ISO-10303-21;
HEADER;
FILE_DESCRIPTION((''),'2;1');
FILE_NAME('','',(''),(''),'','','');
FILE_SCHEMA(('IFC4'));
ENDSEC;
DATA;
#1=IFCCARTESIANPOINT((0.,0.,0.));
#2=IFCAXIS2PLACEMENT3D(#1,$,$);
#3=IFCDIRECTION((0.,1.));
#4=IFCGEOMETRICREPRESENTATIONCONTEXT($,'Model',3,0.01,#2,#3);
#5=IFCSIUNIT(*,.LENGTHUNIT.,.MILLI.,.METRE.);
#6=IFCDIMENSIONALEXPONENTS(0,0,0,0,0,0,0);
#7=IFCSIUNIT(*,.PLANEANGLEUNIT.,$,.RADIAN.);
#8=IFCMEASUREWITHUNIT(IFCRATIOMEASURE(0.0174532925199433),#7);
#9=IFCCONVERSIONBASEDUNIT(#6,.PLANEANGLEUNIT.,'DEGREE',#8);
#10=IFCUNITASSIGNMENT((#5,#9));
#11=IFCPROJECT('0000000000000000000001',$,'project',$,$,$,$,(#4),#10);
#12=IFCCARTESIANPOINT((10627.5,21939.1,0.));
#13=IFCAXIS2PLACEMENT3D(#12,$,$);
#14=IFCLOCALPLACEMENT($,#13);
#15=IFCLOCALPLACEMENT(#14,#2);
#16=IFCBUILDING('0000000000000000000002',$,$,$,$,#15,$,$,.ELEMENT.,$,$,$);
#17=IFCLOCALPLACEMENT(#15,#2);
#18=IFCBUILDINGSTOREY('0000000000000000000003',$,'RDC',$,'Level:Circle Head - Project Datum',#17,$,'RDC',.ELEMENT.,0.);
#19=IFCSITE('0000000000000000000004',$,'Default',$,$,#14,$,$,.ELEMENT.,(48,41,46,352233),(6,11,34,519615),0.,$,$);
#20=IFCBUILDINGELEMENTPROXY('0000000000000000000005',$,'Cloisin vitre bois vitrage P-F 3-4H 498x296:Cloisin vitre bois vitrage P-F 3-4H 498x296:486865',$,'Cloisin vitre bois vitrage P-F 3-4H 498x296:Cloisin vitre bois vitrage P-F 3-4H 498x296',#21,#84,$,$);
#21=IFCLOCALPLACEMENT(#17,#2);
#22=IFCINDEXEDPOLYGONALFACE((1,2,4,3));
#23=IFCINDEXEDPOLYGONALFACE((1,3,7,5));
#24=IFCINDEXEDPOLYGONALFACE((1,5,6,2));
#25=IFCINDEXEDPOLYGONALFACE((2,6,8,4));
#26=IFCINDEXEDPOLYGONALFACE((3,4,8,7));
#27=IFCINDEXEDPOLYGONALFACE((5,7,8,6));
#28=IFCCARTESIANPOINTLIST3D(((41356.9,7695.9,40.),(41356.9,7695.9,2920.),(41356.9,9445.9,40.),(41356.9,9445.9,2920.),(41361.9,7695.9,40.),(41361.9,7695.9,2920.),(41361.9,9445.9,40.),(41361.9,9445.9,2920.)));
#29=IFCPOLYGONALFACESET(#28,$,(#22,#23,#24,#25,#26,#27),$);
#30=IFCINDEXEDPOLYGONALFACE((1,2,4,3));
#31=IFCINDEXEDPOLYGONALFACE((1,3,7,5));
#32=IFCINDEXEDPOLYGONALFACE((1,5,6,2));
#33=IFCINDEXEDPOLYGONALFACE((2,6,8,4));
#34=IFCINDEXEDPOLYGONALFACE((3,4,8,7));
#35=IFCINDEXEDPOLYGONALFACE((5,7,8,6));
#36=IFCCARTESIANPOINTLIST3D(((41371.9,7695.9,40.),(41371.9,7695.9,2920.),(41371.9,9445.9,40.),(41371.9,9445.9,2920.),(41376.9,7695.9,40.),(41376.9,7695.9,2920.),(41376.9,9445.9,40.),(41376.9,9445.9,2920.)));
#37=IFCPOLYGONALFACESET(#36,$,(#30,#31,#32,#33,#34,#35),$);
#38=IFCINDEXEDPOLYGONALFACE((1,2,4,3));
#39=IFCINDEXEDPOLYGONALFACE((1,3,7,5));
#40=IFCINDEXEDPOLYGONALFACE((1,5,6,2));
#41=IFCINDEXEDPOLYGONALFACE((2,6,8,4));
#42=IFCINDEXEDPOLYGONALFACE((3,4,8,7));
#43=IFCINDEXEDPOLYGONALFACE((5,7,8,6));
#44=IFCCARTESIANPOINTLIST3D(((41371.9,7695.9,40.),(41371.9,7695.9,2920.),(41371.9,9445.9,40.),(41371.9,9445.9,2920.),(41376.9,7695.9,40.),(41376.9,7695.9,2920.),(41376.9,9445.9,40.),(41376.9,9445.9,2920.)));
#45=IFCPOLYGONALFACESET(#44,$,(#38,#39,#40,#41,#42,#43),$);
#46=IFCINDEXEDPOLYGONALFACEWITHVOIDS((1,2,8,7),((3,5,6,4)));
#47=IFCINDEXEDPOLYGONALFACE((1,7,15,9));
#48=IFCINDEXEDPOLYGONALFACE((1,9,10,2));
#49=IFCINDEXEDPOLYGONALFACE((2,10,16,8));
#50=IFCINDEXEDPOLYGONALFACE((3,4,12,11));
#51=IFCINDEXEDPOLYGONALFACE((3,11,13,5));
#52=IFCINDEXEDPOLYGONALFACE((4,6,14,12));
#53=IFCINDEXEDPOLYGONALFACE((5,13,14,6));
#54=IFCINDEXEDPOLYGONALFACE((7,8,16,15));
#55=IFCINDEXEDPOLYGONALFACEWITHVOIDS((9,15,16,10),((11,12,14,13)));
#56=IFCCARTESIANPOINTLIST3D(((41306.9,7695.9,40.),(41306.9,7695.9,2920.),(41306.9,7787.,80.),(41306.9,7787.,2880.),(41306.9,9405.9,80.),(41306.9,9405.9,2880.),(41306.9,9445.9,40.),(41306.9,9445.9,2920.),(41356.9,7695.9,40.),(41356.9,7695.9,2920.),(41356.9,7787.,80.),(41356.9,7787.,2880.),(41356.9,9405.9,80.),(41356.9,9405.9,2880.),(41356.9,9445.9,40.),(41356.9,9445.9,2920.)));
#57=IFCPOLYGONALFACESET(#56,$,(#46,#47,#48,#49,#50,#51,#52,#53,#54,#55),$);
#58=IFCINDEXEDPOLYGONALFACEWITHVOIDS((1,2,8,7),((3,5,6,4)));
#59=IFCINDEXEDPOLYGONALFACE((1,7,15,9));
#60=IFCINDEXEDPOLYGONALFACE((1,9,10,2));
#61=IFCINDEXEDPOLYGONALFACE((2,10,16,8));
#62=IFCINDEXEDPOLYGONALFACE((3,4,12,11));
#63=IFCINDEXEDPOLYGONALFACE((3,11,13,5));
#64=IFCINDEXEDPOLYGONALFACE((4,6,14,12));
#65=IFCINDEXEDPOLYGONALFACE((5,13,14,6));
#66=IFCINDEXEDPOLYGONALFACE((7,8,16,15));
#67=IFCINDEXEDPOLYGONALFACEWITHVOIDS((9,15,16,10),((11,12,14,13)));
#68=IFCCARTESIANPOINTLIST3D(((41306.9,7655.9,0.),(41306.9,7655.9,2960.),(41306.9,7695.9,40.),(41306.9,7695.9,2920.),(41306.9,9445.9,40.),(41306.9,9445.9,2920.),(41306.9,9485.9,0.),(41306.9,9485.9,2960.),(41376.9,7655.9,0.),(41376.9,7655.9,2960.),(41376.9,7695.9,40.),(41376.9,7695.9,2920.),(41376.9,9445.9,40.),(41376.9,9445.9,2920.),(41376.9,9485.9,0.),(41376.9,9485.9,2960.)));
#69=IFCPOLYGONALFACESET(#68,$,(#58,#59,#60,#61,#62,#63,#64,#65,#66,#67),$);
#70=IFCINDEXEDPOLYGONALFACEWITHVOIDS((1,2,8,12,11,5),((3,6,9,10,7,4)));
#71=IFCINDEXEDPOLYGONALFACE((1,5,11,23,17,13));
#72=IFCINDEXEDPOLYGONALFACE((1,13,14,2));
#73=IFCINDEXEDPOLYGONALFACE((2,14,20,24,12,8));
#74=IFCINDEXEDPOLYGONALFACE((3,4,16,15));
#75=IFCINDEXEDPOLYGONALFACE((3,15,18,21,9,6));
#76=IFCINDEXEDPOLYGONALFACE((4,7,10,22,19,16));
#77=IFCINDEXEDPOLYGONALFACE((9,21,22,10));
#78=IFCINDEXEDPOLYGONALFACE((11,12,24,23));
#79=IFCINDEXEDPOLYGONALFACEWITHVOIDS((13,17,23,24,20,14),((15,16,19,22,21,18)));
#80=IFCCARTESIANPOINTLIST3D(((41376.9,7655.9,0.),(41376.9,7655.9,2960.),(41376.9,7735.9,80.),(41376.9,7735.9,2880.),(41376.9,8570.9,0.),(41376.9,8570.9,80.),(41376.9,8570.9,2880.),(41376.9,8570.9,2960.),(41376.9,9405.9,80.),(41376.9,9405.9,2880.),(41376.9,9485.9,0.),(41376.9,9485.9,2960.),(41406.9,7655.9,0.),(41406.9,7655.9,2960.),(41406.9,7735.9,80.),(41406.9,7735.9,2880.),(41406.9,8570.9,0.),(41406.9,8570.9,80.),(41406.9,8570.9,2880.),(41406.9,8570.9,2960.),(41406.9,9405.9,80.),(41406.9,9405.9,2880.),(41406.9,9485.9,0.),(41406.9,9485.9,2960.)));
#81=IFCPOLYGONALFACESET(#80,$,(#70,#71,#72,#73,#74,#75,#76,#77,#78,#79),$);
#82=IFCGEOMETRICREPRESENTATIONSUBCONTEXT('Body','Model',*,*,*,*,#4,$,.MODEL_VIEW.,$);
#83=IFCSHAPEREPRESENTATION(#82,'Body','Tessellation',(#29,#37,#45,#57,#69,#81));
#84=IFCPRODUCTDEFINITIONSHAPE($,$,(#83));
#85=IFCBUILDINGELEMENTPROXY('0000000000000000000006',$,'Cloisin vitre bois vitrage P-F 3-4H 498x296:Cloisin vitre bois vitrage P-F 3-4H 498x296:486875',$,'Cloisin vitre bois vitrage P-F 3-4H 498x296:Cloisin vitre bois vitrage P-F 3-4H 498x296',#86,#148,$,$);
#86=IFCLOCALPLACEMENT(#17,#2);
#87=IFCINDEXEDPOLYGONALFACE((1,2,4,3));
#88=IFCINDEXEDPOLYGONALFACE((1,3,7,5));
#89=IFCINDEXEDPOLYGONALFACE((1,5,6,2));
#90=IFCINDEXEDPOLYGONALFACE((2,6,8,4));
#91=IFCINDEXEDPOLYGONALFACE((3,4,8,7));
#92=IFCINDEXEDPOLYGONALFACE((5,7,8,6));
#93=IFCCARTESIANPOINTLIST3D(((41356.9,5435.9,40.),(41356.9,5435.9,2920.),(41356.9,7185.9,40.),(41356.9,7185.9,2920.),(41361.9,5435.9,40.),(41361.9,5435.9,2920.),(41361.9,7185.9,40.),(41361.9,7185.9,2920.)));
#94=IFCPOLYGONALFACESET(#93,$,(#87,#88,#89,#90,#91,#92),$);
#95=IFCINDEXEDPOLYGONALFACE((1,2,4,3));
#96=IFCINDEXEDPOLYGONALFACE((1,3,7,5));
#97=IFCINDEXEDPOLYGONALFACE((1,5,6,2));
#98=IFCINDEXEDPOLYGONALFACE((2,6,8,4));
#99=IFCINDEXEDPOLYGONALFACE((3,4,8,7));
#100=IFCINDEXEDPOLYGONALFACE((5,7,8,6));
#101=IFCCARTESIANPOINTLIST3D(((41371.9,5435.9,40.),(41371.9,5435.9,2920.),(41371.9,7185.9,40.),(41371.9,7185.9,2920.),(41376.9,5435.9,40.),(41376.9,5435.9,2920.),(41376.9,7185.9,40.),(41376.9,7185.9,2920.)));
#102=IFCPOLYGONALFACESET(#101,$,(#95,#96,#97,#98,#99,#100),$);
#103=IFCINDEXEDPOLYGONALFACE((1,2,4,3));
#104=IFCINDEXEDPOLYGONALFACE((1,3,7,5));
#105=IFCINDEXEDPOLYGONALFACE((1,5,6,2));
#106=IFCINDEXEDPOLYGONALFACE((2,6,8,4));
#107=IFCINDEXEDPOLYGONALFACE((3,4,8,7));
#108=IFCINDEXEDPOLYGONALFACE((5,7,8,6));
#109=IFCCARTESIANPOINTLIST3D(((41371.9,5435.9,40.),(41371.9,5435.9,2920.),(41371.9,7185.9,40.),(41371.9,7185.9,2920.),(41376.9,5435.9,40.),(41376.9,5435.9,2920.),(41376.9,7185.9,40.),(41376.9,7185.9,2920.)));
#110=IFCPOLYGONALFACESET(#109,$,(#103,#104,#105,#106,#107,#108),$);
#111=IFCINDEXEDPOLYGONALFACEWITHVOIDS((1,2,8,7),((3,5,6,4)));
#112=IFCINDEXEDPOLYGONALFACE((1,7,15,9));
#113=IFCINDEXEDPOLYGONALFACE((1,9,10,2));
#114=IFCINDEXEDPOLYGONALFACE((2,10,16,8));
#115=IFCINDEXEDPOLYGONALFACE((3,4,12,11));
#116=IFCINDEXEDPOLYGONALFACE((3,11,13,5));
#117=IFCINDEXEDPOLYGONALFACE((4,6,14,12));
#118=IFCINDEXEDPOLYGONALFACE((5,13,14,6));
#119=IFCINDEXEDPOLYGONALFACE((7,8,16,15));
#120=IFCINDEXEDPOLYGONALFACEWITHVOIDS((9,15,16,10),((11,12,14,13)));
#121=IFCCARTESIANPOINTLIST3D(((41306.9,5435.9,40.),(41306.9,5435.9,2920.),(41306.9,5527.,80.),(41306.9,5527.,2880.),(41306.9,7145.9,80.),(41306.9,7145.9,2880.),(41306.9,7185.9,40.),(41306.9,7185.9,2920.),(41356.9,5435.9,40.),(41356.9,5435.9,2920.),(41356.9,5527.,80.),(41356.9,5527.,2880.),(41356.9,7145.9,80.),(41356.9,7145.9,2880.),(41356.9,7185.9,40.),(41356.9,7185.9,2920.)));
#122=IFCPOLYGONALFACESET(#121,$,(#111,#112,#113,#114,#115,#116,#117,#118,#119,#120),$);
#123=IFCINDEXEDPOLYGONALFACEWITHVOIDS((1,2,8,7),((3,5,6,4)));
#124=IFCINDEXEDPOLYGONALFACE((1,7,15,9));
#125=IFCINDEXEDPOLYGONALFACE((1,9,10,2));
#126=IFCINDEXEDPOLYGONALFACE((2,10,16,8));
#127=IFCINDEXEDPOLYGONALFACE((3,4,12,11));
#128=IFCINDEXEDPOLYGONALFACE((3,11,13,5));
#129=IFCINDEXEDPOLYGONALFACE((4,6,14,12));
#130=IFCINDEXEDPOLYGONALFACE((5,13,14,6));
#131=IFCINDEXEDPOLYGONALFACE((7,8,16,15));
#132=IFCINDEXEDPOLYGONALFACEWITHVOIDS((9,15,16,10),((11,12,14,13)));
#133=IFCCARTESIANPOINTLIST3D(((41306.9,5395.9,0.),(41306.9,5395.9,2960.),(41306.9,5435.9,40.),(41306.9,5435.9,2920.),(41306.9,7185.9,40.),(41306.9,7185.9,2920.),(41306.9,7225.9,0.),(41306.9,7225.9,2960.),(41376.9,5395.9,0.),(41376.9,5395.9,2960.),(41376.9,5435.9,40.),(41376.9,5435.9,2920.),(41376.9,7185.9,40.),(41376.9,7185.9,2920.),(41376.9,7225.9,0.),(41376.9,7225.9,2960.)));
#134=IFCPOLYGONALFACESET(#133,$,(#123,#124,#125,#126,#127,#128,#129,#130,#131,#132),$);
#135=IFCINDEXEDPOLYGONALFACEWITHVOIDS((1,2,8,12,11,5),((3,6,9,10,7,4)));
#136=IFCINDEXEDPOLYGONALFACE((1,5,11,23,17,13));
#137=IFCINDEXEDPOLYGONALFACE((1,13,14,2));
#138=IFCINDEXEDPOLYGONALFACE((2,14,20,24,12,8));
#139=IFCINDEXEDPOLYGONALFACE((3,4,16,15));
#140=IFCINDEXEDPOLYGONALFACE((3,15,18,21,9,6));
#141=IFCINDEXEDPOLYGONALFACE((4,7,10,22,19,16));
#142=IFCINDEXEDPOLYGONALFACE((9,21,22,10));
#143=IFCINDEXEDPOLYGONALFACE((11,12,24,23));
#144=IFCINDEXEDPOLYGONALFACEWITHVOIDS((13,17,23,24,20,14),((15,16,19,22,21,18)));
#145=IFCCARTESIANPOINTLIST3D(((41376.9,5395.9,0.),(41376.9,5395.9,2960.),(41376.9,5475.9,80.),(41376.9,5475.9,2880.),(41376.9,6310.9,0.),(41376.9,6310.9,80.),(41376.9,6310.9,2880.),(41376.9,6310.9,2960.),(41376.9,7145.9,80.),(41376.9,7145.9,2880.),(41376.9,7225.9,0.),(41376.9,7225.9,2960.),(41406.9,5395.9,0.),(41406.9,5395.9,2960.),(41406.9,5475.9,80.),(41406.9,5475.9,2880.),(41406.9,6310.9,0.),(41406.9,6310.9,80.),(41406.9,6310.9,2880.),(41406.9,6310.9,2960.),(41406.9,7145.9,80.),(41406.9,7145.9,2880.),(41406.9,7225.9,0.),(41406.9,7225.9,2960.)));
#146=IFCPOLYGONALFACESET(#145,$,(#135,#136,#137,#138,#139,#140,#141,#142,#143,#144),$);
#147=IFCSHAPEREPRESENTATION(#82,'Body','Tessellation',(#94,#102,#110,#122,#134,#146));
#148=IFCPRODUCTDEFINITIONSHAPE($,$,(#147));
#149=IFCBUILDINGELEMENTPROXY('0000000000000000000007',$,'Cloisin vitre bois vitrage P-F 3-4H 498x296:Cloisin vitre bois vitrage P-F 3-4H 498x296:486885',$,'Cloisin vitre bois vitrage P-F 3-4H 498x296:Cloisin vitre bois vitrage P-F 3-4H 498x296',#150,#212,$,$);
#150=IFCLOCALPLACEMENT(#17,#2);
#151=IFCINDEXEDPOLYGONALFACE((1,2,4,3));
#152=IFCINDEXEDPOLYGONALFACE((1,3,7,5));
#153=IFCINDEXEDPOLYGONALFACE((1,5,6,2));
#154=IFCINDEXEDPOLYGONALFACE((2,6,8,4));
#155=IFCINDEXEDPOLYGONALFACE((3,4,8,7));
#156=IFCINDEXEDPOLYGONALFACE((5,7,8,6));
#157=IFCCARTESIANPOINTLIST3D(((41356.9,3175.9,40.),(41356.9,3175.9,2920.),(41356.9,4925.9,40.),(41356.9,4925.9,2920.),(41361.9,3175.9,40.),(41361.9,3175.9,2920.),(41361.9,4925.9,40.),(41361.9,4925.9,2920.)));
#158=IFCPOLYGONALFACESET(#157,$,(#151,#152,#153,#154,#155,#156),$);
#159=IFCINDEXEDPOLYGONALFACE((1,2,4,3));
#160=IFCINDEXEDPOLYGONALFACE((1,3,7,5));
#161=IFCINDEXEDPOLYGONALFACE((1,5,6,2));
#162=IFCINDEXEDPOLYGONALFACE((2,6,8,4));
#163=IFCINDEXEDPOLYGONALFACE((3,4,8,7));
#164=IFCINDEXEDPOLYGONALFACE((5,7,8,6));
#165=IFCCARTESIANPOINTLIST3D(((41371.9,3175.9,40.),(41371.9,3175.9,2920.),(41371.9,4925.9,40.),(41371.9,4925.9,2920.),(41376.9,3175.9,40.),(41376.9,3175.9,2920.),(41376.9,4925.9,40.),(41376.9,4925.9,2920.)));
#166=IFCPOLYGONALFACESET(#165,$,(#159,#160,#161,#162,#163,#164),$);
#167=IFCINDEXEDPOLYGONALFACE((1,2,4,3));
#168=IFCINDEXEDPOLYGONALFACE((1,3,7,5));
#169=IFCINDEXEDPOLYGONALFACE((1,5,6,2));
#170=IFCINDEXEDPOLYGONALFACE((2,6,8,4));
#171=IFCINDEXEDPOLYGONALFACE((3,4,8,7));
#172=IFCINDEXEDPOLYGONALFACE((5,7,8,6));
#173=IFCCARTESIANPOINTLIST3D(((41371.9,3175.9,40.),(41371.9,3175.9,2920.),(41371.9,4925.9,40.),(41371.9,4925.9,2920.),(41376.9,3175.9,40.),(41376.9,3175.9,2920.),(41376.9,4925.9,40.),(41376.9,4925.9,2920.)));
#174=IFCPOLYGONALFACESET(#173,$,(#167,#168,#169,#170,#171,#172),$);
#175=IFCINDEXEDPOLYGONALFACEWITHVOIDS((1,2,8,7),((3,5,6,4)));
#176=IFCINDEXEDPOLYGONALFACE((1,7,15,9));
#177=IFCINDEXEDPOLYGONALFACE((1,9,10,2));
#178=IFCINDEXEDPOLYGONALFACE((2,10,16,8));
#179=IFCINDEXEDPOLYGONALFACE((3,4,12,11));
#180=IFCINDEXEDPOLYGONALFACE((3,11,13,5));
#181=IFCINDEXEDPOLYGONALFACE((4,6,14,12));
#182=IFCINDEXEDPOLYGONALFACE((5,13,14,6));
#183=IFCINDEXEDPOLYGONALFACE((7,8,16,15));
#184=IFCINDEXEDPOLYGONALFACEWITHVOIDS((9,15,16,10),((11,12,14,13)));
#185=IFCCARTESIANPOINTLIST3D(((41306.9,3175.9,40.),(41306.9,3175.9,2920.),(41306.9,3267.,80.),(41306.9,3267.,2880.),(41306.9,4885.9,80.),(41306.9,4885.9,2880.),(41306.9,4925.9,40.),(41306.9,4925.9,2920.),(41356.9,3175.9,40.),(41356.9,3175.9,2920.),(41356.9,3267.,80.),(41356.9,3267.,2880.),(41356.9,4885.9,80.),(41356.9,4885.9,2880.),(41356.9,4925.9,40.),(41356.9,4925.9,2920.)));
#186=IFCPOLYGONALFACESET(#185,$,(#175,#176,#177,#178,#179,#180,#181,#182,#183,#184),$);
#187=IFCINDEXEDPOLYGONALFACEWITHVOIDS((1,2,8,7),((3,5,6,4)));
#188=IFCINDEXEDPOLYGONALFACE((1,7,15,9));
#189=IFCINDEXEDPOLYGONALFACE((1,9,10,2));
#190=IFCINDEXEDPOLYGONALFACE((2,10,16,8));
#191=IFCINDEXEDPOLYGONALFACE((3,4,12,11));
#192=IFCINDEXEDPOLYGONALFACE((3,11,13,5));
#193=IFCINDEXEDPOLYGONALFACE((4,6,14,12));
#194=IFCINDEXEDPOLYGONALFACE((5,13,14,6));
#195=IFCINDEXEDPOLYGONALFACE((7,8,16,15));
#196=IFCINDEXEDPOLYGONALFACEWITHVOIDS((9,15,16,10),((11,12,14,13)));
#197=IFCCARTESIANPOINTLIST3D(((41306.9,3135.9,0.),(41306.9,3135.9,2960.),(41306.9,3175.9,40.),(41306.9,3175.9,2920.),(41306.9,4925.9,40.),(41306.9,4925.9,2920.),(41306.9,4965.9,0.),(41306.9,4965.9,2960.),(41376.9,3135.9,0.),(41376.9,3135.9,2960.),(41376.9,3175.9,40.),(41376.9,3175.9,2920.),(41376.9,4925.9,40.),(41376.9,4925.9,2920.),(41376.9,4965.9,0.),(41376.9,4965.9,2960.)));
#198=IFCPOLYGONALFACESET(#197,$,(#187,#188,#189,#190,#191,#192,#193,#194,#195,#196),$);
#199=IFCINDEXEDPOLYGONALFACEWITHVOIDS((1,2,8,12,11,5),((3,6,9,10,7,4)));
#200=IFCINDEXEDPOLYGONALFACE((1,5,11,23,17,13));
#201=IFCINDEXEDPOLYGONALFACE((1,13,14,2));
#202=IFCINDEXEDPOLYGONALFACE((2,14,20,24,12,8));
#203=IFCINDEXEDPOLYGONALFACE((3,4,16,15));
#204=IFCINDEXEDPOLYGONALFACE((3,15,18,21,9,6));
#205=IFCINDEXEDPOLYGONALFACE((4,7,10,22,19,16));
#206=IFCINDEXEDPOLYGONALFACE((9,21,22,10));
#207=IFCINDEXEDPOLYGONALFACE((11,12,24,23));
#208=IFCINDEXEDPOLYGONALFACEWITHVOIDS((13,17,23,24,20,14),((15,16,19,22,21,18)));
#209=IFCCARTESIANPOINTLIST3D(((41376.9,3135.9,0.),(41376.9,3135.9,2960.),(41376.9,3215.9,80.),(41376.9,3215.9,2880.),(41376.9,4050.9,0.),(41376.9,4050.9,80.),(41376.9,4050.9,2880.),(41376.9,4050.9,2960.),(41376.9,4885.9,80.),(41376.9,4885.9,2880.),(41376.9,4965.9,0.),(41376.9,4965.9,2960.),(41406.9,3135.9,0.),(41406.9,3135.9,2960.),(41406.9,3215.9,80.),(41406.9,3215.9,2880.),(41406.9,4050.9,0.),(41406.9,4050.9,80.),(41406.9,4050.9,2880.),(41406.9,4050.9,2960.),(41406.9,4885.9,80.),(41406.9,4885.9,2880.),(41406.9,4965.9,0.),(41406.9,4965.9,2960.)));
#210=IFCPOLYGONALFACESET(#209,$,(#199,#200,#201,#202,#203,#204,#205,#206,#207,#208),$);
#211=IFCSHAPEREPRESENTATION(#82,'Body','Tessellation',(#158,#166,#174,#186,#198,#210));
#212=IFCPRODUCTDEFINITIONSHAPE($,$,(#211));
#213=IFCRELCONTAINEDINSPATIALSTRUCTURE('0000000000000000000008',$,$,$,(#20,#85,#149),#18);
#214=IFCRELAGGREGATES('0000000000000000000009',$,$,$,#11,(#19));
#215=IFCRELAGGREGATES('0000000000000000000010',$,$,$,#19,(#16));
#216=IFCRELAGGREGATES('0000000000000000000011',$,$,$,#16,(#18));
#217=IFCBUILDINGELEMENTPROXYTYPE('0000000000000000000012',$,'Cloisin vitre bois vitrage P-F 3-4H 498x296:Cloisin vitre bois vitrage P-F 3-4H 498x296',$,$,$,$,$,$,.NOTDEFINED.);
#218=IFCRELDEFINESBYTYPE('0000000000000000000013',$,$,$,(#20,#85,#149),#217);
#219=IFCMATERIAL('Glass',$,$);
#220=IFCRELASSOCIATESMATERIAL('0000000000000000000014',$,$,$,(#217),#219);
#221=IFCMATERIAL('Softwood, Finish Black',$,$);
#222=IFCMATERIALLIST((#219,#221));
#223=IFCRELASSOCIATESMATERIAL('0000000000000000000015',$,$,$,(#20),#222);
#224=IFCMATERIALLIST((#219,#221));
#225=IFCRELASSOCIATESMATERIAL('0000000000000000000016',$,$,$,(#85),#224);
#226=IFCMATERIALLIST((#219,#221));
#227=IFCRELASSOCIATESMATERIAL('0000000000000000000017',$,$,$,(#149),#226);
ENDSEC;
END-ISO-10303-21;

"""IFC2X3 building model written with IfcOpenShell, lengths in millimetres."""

from ifc_helpers import new_model, entity, si_unit, converted_unit, direction, frame, frame_2d, origin, place, context, subcontext, project, spatial, polyline, rectangle, outline, extrude, source, transform, mapped, material, material_list, type_object, type_shapes, element, save


model = new_model("IFC2X3")

# Units and contexts
model_context = context("Model", 3, precision=0.01, world=origin(), true_north=direction((0.0, 1.0)))
body_context = subcontext(model_context, "Body", "Model", "MODEL_VIEW")
ifc_project = project(units=[si_unit("LENGTHUNIT", "METRE", prefix="MILLI"), converted_unit("PLANEANGLEUNIT", "DEGREE", entity("IfcRatioMeasure", 0.0174532925199433), si_unit("PLANEANGLEUNIT", "RADIAN"), dimensions=[0, 0, 0, 0, 0, 0, 0])], contexts=[model_context])

# Site, building, storey
site_placement = place(None, frame((10627.5, 21939.1, 0.0)))
site = spatial("IfcSite", under=ifc_project, at=site_placement, Name="Default", CompositionType="ELEMENT", RefLatitude=(48, 41, 46, 352233), RefLongitude=(6, 11, 34, 519615), RefElevation=0.0)
building_placement = place(site_placement, origin())
building = spatial("IfcBuilding", under=site, at=building_placement, CompositionType="ELEMENT")
storey_placement = place(building_placement, origin())
storey = spatial("IfcBuildingStorey", under=building, at=storey_placement, Name="RDC", ObjectType="Level:Circle Head - Project Datum", LongName="RDC", CompositionType="ELEMENT", Elevation=0.0)

# Building element proxies
ifc_material_1 = material(Name="Glass")
ifc_material_2 = material(Name="Softwood, Finish Black")
building_element_proxy_type_1 = type_object("IfcBuildingElementProxyType", Name="Cloisin vitre bois vitrage P-F 3-4H 498x296:Cloisin vitre bois vitrage P-F 3-4H 498x296", PredefinedType="NOTDEFINED", material=ifc_material_1)
shared_shape_1 = source(origin(), body_context, "Body", "SweptSolid", [
    extrude(rectangle(XDim=5.0, YDim=1750.0, at=frame_2d((0.0, 0.0), x_axis=(1.0, 0.0))), frame((0.0, -47.5, 40.0), z_axis=(0.0, 0.0, 1.0), x_axis=(0.0, 1.0, 0.0)), (0.0, 0.0, 1.0), 2880.0),
    extrude(rectangle(XDim=5.0, YDim=1750.0, at=frame_2d((0.0, 0.0), x_axis=(1.0, 0.0))), frame((0.0, -32.5, 40.0), z_axis=(0.0, 0.0, 1.0), x_axis=(0.0, 1.0, 0.0)), (0.0, 0.0, 1.0), 2880.0),
    extrude(rectangle(XDim=5.0, YDim=1750.0, at=frame_2d((0.0, 0.0), x_axis=(1.0, 0.0))), frame((0.0, -32.5, 40.0), z_axis=(0.0, 0.0, 1.0), x_axis=(0.0, 1.0, 0.0)), (0.0, 0.0, 1.0), 2880.0),
    extrude(outline(polyline([(-1440.0, -875.0), (1440.0, -875.0), (1440.0, 875.0), (-1440.0, 875.0), (-1440.0, -875.0)]), holes=[polyline([(1400.0, 835.0), (1400.0, -783.9), (-1400.0, -783.9), (-1400.0, 835.0), (1400.0, 835.0)])]), frame((0.0, -100.0, 1480.0), z_axis=(0.0, 1.0, 0.0), x_axis=(0.0, 0.0, -1.0)), (0.0, 0.0, 1.0), 50.0),
    extrude(outline(polyline([(-1480.0, -915.0), (1480.0, -915.0), (1480.0, 915.0), (-1480.0, 915.0), (-1480.0, -915.0)]), holes=[polyline([(-1440.0, -875.0), (-1440.0, 875.0), (1440.0, 875.0), (1440.0, -875.0), (-1440.0, -875.0)])]), frame((0.0, -100.0, 1480.0), z_axis=(0.0, 1.0, 0.0), x_axis=(0.0, 0.0, -1.0)), (0.0, 0.0, 1.0), 70.0),
    extrude(outline(polyline([(-1480.0, -915.0), (1480.0, -915.0), (1480.0, 0.0), (1480.0, 915.0), (-1480.0, 915.0), (-1480.0, 0.0), (-1480.0, -915.0)]), holes=[polyline([(1400.0, 0.0), (1400.0, -835.0), (-1400.0, -835.0), (-1400.0, 0.0), (-1400.0, 835.0), (1400.0, 835.0), (1400.0, 0.0)])]), frame((0.0, -30.0, 1480.0), z_axis=(0.0, 1.0, 0.0), x_axis=(0.0, 0.0, 1.0)), (0.0, 0.0, 1.0), 30.0),
])
type_shapes(building_element_proxy_type_1, [shared_shape_1])
ifc_material_list_1 = material_list([ifc_material_1, ifc_material_2])
proxy_1_placement = place(storey_placement, frame((41406.9, 8570.9, 0.0), z_axis=(0.0, 0.0, 1.0), x_axis=(0.0, -1.0, 0.0)))
element("IfcBuildingElementProxy", 1, at=proxy_1_placement, inside=storey, type_object=building_element_proxy_type_1, material=ifc_material_list_1, Name="Cloisin vitre bois vitrage P-F 3-4H 498x296:Cloisin vitre bois vitrage P-F 3-4H 498x296:486865", ObjectType="Cloisin vitre bois vitrage P-F 3-4H 498x296:Cloisin vitre bois vitrage P-F 3-4H 498x296", context=body_context, shape_type="MappedRepresentation", body=[
    mapped(shared_shape_1, transform((0.0, 0.0, 0.0), scale=1.0)),
])
ifc_material_list_2 = material_list([ifc_material_1, ifc_material_2])
proxy_2_placement = place(storey_placement, frame((41406.9, 6310.9, 0.0), z_axis=(0.0, 0.0, 1.0), x_axis=(0.0, -1.0, 0.0)))
element("IfcBuildingElementProxy", 2, at=proxy_2_placement, inside=storey, type_object=building_element_proxy_type_1, material=ifc_material_list_2, Name="Cloisin vitre bois vitrage P-F 3-4H 498x296:Cloisin vitre bois vitrage P-F 3-4H 498x296:486875", ObjectType="Cloisin vitre bois vitrage P-F 3-4H 498x296:Cloisin vitre bois vitrage P-F 3-4H 498x296", context=body_context, shape_type="MappedRepresentation", body=[
    mapped(shared_shape_1, transform((0.0, 0.0, 0.0), scale=1.0)),
])
ifc_material_list_3 = material_list([ifc_material_1, ifc_material_2])
proxy_3_placement = place(storey_placement, frame((41406.9, 4050.9, 0.0), z_axis=(0.0, 0.0, 1.0), x_axis=(0.0, -1.0, 0.0)))
element("IfcBuildingElementProxy", 3, at=proxy_3_placement, inside=storey, type_object=building_element_proxy_type_1, material=ifc_material_list_3, Name="Cloisin vitre bois vitrage P-F 3-4H 498x296:Cloisin vitre bois vitrage P-F 3-4H 498x296:486885", ObjectType="Cloisin vitre bois vitrage P-F 3-4H 498x296:Cloisin vitre bois vitrage P-F 3-4H 498x296", context=body_context, shape_type="MappedRepresentation", body=[
    mapped(shared_shape_1, transform((0.0, 0.0, 0.0), scale=1.0)),
])

save(model, "model.ifc")
